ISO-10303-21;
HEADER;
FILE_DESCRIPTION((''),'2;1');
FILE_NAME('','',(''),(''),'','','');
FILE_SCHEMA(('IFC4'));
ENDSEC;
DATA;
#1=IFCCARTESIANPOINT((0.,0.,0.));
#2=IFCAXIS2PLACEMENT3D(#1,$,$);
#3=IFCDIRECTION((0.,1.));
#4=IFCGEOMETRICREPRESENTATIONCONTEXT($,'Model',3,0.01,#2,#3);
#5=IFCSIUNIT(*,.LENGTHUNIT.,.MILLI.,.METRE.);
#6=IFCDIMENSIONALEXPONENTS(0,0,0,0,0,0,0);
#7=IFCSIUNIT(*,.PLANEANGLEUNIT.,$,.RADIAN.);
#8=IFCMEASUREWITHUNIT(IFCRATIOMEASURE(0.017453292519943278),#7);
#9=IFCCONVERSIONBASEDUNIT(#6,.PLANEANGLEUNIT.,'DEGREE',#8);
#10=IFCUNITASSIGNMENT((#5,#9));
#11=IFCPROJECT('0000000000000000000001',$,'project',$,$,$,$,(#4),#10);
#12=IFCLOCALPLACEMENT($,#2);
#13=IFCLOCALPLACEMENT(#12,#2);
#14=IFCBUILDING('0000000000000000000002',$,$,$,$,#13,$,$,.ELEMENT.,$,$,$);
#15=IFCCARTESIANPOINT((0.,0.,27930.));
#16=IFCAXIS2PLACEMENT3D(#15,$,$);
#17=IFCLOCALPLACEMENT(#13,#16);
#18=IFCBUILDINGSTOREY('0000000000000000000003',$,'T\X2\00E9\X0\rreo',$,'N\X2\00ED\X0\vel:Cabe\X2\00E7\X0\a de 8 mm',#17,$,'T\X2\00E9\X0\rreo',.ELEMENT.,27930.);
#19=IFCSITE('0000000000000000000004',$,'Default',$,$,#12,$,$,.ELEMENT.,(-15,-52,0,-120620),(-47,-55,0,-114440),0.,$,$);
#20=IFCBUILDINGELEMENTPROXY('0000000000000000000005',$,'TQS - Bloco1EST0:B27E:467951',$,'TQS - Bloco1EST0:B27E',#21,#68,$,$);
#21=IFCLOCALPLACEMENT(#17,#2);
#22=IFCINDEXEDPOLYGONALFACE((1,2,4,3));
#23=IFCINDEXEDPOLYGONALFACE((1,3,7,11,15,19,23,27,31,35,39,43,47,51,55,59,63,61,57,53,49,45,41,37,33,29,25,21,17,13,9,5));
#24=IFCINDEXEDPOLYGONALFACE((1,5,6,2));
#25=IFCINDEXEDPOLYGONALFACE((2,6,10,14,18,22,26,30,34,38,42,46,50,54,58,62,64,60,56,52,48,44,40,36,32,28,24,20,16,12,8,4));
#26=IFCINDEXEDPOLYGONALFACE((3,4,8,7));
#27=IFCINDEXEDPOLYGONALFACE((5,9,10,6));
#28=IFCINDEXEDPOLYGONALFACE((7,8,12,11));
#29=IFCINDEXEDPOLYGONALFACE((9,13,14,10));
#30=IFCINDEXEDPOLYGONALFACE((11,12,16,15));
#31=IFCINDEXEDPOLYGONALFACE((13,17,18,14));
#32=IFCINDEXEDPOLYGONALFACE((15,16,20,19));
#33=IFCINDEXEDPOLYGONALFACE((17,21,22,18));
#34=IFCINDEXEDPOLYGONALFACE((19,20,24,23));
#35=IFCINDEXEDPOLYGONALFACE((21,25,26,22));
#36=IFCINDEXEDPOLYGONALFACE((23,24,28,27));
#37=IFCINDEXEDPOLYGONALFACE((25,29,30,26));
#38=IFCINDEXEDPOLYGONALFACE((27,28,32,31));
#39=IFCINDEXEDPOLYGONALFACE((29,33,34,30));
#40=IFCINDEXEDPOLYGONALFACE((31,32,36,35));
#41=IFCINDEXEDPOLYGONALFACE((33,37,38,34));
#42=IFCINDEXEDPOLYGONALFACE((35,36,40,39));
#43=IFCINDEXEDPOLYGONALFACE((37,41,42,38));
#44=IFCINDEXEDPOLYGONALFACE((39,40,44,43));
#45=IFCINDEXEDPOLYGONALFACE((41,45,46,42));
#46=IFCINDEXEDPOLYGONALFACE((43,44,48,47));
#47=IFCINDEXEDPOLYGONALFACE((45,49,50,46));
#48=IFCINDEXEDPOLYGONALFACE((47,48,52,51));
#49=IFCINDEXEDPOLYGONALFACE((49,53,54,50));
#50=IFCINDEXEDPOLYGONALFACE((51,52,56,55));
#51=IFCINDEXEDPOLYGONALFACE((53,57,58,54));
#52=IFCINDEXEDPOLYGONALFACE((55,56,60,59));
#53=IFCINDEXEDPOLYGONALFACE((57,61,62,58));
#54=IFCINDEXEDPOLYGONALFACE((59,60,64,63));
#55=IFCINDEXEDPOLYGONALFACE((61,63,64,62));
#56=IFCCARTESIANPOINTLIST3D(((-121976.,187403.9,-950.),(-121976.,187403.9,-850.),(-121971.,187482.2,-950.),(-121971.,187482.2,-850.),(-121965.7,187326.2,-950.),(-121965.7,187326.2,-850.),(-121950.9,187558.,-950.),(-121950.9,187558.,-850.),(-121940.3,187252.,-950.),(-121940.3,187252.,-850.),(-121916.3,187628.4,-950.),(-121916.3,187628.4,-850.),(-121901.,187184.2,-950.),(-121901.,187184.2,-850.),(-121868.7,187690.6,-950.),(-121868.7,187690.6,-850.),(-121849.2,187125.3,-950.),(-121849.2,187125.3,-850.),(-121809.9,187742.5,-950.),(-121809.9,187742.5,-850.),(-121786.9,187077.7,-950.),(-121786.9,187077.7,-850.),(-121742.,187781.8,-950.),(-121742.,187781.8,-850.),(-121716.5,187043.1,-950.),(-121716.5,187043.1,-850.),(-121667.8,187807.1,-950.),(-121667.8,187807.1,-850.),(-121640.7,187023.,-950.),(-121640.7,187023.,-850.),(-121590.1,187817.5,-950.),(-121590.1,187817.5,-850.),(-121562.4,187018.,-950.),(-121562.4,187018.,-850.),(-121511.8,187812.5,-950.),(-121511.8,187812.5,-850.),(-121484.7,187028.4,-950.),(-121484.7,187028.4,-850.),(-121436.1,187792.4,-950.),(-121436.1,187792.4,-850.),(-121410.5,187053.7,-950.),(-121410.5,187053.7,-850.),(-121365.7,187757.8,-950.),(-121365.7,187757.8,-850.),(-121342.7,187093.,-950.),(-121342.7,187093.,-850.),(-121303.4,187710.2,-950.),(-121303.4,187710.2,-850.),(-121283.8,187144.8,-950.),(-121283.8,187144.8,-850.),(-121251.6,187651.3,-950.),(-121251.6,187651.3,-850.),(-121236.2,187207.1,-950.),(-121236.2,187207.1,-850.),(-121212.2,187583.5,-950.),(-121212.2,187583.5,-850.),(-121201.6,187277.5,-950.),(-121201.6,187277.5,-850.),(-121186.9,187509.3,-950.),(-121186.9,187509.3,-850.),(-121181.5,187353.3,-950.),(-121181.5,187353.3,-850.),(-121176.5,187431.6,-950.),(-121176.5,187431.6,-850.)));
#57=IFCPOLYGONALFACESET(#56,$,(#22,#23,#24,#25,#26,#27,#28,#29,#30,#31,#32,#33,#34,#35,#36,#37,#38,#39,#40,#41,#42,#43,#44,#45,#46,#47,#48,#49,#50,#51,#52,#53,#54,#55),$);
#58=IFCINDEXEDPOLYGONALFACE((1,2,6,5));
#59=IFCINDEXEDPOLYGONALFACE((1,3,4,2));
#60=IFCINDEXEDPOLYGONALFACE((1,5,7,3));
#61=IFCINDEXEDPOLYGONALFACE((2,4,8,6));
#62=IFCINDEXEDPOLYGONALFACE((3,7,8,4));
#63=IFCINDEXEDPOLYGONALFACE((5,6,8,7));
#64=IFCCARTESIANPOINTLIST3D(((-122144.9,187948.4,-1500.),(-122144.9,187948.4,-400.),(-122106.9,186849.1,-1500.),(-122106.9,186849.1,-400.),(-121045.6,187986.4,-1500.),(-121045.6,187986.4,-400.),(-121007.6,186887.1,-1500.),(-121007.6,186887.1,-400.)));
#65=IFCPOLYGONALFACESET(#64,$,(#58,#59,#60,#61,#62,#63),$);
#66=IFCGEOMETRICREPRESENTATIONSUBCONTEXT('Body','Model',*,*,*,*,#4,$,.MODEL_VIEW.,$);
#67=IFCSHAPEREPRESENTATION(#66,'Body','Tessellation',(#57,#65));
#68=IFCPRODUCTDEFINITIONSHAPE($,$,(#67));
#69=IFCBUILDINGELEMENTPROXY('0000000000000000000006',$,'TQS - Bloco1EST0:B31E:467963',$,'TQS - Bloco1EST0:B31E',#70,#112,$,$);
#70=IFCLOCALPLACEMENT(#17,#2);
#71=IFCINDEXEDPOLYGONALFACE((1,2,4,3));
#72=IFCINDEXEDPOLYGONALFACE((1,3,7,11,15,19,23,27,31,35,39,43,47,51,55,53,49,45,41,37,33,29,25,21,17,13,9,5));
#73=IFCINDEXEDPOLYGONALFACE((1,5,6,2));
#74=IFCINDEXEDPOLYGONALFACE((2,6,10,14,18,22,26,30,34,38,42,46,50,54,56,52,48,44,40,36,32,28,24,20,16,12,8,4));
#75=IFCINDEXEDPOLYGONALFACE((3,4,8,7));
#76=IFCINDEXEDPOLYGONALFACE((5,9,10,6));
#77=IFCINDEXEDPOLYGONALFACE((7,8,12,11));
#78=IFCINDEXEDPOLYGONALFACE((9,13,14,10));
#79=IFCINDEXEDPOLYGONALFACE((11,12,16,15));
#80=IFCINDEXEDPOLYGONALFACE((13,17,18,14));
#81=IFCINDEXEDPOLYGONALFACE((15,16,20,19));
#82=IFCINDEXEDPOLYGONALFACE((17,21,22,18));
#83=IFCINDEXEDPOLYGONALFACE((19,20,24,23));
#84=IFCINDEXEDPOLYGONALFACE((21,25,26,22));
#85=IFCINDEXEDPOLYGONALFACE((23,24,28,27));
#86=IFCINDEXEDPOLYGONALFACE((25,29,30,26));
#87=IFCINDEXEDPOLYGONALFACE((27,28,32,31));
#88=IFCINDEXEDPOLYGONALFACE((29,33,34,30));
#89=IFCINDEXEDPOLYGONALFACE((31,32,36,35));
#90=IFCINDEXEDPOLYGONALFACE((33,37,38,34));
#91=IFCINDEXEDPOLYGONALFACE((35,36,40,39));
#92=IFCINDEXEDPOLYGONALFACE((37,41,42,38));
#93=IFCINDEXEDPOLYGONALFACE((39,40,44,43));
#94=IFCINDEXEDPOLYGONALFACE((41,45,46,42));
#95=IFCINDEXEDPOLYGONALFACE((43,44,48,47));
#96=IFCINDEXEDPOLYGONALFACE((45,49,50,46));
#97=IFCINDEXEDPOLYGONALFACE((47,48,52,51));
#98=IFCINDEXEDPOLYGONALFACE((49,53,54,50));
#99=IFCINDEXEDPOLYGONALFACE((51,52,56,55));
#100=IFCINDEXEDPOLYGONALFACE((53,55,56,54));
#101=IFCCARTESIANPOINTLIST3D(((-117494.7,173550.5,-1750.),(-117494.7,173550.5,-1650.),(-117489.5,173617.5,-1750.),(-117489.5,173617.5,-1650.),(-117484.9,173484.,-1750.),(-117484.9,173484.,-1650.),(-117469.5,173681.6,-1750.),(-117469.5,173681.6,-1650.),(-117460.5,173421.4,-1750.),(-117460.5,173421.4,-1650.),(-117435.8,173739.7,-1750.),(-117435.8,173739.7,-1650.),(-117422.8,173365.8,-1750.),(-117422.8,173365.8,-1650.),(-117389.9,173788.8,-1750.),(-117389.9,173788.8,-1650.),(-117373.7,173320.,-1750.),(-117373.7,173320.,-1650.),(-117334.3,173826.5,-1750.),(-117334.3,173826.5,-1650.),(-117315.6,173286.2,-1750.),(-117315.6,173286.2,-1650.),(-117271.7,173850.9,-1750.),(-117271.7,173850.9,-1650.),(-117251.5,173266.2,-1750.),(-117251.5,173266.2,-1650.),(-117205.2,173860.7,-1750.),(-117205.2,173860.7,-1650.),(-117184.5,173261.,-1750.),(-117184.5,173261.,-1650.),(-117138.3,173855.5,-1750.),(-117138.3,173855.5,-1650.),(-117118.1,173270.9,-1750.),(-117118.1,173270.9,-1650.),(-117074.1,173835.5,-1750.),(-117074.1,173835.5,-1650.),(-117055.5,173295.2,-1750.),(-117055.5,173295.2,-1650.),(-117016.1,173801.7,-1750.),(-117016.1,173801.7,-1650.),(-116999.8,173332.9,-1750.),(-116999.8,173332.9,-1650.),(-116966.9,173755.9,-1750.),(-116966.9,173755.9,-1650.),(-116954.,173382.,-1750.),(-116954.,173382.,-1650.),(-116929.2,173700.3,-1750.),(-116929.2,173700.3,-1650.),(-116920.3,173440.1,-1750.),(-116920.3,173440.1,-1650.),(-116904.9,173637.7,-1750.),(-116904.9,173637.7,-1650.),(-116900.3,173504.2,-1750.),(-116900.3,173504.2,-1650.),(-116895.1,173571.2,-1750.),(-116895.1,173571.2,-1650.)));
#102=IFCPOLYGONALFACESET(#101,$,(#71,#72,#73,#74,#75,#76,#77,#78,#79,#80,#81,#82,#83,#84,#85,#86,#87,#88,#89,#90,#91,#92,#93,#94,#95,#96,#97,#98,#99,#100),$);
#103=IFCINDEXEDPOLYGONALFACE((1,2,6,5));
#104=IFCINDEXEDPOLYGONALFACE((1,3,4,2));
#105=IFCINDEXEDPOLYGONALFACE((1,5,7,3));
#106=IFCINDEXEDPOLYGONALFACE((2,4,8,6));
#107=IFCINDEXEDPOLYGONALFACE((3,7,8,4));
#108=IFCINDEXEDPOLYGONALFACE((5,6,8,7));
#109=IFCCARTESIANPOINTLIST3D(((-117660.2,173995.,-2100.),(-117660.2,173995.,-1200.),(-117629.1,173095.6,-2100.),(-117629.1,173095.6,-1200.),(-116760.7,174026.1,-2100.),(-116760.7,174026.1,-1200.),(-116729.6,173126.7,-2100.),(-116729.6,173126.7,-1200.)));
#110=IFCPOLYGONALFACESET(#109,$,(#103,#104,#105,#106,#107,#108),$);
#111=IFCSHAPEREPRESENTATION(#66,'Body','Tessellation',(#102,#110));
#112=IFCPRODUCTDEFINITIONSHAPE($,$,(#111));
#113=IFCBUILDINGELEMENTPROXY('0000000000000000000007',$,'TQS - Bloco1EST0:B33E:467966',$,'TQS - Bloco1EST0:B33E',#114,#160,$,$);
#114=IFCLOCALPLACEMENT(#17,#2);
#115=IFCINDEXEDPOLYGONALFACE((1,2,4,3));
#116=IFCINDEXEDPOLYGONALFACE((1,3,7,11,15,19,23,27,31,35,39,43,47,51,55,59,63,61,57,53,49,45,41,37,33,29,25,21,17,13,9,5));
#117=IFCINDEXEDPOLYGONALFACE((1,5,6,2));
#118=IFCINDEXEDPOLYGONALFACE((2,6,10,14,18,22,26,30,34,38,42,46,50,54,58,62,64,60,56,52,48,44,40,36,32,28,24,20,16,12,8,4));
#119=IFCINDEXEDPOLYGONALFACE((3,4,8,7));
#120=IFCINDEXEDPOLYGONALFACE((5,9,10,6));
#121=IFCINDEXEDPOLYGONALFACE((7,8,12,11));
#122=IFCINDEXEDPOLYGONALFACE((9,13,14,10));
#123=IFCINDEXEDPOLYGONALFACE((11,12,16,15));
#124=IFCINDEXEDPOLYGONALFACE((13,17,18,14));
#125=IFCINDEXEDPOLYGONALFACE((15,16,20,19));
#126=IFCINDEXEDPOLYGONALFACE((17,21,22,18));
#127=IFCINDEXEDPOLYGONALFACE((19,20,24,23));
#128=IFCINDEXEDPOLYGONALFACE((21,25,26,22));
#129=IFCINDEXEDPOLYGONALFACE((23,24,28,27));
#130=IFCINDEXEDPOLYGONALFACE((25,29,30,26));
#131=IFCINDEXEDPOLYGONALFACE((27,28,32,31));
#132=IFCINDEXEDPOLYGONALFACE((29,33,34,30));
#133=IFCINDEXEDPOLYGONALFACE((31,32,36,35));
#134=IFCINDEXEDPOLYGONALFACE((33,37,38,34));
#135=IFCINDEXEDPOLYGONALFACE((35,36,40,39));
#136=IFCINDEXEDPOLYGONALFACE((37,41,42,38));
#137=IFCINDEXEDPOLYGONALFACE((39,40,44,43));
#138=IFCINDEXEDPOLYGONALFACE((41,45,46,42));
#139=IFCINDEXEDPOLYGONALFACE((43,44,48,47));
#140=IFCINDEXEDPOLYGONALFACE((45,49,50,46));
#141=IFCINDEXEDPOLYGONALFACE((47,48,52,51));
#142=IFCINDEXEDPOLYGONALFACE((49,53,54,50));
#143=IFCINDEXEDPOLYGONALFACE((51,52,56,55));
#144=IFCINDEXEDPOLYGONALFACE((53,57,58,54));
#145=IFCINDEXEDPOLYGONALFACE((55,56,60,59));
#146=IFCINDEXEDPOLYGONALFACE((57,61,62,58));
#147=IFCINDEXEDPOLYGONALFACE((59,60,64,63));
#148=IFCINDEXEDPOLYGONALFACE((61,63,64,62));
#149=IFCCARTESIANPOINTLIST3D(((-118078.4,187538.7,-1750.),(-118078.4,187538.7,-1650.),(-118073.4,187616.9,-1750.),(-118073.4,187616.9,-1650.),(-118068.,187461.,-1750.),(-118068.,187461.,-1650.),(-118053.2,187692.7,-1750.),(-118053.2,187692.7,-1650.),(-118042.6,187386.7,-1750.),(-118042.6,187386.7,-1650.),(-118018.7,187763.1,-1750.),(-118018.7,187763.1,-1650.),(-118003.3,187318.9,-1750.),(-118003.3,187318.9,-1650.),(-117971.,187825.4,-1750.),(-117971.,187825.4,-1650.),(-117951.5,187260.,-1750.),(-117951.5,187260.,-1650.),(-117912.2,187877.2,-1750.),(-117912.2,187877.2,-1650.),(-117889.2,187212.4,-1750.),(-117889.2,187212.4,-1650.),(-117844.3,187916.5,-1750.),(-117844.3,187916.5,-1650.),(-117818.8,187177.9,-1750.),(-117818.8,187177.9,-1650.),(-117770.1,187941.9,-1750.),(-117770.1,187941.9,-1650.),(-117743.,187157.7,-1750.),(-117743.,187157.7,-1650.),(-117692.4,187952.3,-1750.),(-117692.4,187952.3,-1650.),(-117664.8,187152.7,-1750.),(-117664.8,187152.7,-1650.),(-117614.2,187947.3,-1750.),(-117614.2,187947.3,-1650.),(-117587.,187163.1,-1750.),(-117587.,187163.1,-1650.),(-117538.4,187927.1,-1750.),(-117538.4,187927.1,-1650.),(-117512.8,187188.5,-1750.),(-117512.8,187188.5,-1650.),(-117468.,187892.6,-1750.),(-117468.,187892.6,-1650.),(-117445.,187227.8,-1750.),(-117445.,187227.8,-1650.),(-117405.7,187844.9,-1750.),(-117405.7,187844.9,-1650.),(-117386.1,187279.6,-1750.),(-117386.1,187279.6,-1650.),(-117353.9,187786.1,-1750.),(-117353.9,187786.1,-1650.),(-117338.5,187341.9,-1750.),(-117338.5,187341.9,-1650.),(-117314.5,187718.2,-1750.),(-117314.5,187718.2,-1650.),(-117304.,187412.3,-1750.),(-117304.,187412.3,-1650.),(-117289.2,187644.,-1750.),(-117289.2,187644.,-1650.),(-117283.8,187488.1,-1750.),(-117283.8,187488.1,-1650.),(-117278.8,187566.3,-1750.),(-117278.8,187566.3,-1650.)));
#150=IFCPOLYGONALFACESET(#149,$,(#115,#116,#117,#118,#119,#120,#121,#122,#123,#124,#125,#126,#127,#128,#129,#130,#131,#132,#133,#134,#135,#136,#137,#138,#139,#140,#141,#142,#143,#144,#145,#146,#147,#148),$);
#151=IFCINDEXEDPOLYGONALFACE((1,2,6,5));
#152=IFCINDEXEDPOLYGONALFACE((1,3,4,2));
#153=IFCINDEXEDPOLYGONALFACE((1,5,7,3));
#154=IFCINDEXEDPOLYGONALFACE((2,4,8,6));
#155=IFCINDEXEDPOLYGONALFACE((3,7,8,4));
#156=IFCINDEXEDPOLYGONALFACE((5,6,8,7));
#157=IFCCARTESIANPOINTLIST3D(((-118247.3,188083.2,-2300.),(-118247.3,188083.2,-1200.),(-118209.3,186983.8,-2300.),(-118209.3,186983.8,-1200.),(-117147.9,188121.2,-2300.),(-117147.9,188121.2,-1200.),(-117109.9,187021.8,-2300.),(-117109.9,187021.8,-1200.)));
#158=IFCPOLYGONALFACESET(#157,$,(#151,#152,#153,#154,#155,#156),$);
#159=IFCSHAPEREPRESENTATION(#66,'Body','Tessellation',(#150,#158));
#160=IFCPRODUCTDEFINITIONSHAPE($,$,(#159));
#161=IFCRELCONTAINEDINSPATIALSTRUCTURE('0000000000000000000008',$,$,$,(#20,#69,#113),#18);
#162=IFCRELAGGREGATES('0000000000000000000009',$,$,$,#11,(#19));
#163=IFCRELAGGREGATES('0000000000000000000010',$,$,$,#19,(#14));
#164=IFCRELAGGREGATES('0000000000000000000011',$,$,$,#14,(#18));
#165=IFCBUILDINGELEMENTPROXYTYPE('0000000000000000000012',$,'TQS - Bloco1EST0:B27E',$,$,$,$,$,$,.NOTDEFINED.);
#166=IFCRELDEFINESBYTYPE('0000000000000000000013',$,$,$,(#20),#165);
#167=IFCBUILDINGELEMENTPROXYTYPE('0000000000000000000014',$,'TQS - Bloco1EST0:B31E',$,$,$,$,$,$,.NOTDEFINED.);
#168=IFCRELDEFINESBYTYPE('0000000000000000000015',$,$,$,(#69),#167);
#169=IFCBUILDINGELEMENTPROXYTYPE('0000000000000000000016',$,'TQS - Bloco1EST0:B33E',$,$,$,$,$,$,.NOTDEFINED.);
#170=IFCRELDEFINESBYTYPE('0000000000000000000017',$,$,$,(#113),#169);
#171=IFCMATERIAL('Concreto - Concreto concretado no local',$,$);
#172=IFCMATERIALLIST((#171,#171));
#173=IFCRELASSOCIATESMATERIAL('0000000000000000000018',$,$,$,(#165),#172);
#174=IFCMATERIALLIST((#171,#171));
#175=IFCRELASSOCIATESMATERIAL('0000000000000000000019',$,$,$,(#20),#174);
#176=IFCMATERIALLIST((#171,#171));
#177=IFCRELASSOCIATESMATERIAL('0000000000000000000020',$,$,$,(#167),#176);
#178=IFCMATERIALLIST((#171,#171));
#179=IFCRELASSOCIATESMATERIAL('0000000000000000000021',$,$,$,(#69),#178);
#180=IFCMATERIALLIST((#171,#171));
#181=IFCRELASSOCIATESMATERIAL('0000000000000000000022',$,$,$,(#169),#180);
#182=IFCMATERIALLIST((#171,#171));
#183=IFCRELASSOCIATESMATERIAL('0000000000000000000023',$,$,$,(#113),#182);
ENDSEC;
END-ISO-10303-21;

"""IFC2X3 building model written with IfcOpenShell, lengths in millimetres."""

from ifc_helpers import new_model, entity, si_unit, converted_unit, direction, frame, frame_2d, origin, origin_2d_with_axis, place, context, subcontext, project, spatial, rectangle, circle, extrude, source, transform, mapped, material, material_list, type_object, type_shapes, element, save


model = new_model("IFC2X3")

# Units and contexts
model_context = context("Model", 3, precision=0.01, world=origin(), true_north=direction((0.0, 1.0)))
body_context = subcontext(model_context, "Body", "Model", "MODEL_VIEW")
ifc_project = project(units=[si_unit("LENGTHUNIT", "METRE", prefix="MILLI"), converted_unit("PLANEANGLEUNIT", "DEGREE", entity("IfcRatioMeasure", 0.017453292519943278), si_unit("PLANEANGLEUNIT", "RADIAN"), dimensions=[0, 0, 0, 0, 0, 0, 0])], contexts=[model_context])

# Site, building, storey
site_placement = place(None, origin())
site = spatial("IfcSite", under=ifc_project, at=site_placement, Name="Default", CompositionType="ELEMENT", RefLatitude=(-15, -52, 0, -120620), RefLongitude=(-47, -55, 0, -114440), RefElevation=0.0)
building_placement = place(site_placement, origin())
building = spatial("IfcBuilding", under=site, at=building_placement, CompositionType="ELEMENT")
storey_placement = place(building_placement, frame((0.0, 0.0, 27930.0)))
storey = spatial("IfcBuildingStorey", under=building, at=storey_placement, Name="Térreo", ObjectType="Nível:Cabeça de 8 mm", LongName="Térreo", CompositionType="ELEMENT", Elevation=27930.0)

# Building element proxies
ifc_material_1 = material(Name="Concreto - Concreto concretado no local")
ifc_material_list_1 = material_list([ifc_material_1, ifc_material_1])
ifc_material_list_2 = material_list([ifc_material_1, ifc_material_1])
building_element_proxy_type_1 = type_object("IfcBuildingElementProxyType", Name="TQS - Bloco1EST0:B27E", PredefinedType="NOTDEFINED", material=ifc_material_list_2)
shared_shape_1 = source(origin(), body_context, "Body", "SweptSolid", [
    extrude(circle(Radius=400.0, at=frame_2d((0.0, 0.0), x_axis=(1.0, 0.0))), frame((0.0, 0.0, -550.0)), (0.0, 0.0, 1.0), 100.0),
    extrude(rectangle(XDim=1100.0, YDim=1100.0, at=origin_2d_with_axis()), frame((0.0, 0.0, -1100.0), z_axis=(0.0, 0.0, 1.0), x_axis=(-1.0, 0.0, 0.0)), (0.0, 0.0, 1.0), 1100.0),
])
type_shapes(building_element_proxy_type_1, [shared_shape_1])
proxy_1_placement = place(storey_placement, frame((-121576.3, 187417.7, -400.0), z_axis=(0.0, 0.0, 1.0), x_axis=(-0.034551, 0.999403, 0.0)))
element("IfcBuildingElementProxy", 1, at=proxy_1_placement, inside=storey, type_object=building_element_proxy_type_1, material=ifc_material_list_1, Name="TQS - Bloco1EST0:B27E:467951", ObjectType="TQS - Bloco1EST0:B27E", context=body_context, shape_type="MappedRepresentation", body=[
    mapped(shared_shape_1, transform((0.0, 0.0, 0.0), scale=1.0)),
])
ifc_material_list_3 = material_list([ifc_material_1, ifc_material_1])
ifc_material_list_4 = material_list([ifc_material_1, ifc_material_1])
building_element_proxy_type_2 = type_object("IfcBuildingElementProxyType", Name="TQS - Bloco1EST0:B31E", PredefinedType="NOTDEFINED", material=ifc_material_list_4)
shared_shape_2 = source(origin(), body_context, "Body", "SweptSolid", [
    extrude(circle(Radius=300.0, at=frame_2d((0.0, 0.0), x_axis=(1.0, 0.0))), frame((0.0, 0.0, -550.0)), (0.0, 0.0, 1.0), 100.0),
    extrude(rectangle(XDim=900.0, YDim=900.0, at=origin_2d_with_axis()), frame((0.0, 0.0, -900.0), z_axis=(0.0, 0.0, 1.0), x_axis=(-1.0, 0.0, 0.0)), (0.0, 0.0, 1.0), 900.0),
])
type_shapes(building_element_proxy_type_2, [shared_shape_2])
proxy_2_placement = place(storey_placement, frame((-117194.9, 173560.9, -1200.0), z_axis=(0.0, 0.0, 1.0), x_axis=(-0.034551, 0.999403, 0.0)))
element("IfcBuildingElementProxy", 2, at=proxy_2_placement, inside=storey, type_object=building_element_proxy_type_2, material=ifc_material_list_3, Name="TQS - Bloco1EST0:B31E:467963", ObjectType="TQS - Bloco1EST0:B31E", context=body_context, shape_type="MappedRepresentation", body=[
    mapped(shared_shape_2, transform((0.0, 0.0, 0.0), scale=1.0)),
])
ifc_material_list_5 = material_list([ifc_material_1, ifc_material_1])
ifc_material_list_6 = material_list([ifc_material_1, ifc_material_1])
building_element_proxy_type_3 = type_object("IfcBuildingElementProxyType", Name="TQS - Bloco1EST0:B33E", PredefinedType="NOTDEFINED", material=ifc_material_list_6)
shared_shape_3 = source(origin(), body_context, "Body", "SweptSolid", [
    extrude(circle(Radius=400.0, at=frame_2d((0.0, 0.0), x_axis=(1.0, 0.0))), frame((0.0, 0.0, -550.0)), (0.0, 0.0, 1.0), 100.0),
    extrude(rectangle(XDim=1100.0, YDim=1100.0, at=origin_2d_with_axis()), frame((0.0, 0.0, -1100.0), z_axis=(0.0, 0.0, 1.0), x_axis=(-1.0, 0.0, 0.0)), (0.0, 0.0, 1.0), 1100.0),
])
type_shapes(building_element_proxy_type_3, [shared_shape_3])
proxy_3_placement = place(storey_placement, frame((-117678.6, 187552.5, -1200.0), z_axis=(0.0, 0.0, 1.0), x_axis=(-0.034551, 0.999403, 0.0)))
element("IfcBuildingElementProxy", 3, at=proxy_3_placement, inside=storey, type_object=building_element_proxy_type_3, material=ifc_material_list_5, Name="TQS - Bloco1EST0:B33E:467966", ObjectType="TQS - Bloco1EST0:B33E", context=body_context, shape_type="MappedRepresentation", body=[
    mapped(shared_shape_3, transform((0.0, 0.0, 0.0), scale=1.0)),
])

save(model, "model.ifc")
